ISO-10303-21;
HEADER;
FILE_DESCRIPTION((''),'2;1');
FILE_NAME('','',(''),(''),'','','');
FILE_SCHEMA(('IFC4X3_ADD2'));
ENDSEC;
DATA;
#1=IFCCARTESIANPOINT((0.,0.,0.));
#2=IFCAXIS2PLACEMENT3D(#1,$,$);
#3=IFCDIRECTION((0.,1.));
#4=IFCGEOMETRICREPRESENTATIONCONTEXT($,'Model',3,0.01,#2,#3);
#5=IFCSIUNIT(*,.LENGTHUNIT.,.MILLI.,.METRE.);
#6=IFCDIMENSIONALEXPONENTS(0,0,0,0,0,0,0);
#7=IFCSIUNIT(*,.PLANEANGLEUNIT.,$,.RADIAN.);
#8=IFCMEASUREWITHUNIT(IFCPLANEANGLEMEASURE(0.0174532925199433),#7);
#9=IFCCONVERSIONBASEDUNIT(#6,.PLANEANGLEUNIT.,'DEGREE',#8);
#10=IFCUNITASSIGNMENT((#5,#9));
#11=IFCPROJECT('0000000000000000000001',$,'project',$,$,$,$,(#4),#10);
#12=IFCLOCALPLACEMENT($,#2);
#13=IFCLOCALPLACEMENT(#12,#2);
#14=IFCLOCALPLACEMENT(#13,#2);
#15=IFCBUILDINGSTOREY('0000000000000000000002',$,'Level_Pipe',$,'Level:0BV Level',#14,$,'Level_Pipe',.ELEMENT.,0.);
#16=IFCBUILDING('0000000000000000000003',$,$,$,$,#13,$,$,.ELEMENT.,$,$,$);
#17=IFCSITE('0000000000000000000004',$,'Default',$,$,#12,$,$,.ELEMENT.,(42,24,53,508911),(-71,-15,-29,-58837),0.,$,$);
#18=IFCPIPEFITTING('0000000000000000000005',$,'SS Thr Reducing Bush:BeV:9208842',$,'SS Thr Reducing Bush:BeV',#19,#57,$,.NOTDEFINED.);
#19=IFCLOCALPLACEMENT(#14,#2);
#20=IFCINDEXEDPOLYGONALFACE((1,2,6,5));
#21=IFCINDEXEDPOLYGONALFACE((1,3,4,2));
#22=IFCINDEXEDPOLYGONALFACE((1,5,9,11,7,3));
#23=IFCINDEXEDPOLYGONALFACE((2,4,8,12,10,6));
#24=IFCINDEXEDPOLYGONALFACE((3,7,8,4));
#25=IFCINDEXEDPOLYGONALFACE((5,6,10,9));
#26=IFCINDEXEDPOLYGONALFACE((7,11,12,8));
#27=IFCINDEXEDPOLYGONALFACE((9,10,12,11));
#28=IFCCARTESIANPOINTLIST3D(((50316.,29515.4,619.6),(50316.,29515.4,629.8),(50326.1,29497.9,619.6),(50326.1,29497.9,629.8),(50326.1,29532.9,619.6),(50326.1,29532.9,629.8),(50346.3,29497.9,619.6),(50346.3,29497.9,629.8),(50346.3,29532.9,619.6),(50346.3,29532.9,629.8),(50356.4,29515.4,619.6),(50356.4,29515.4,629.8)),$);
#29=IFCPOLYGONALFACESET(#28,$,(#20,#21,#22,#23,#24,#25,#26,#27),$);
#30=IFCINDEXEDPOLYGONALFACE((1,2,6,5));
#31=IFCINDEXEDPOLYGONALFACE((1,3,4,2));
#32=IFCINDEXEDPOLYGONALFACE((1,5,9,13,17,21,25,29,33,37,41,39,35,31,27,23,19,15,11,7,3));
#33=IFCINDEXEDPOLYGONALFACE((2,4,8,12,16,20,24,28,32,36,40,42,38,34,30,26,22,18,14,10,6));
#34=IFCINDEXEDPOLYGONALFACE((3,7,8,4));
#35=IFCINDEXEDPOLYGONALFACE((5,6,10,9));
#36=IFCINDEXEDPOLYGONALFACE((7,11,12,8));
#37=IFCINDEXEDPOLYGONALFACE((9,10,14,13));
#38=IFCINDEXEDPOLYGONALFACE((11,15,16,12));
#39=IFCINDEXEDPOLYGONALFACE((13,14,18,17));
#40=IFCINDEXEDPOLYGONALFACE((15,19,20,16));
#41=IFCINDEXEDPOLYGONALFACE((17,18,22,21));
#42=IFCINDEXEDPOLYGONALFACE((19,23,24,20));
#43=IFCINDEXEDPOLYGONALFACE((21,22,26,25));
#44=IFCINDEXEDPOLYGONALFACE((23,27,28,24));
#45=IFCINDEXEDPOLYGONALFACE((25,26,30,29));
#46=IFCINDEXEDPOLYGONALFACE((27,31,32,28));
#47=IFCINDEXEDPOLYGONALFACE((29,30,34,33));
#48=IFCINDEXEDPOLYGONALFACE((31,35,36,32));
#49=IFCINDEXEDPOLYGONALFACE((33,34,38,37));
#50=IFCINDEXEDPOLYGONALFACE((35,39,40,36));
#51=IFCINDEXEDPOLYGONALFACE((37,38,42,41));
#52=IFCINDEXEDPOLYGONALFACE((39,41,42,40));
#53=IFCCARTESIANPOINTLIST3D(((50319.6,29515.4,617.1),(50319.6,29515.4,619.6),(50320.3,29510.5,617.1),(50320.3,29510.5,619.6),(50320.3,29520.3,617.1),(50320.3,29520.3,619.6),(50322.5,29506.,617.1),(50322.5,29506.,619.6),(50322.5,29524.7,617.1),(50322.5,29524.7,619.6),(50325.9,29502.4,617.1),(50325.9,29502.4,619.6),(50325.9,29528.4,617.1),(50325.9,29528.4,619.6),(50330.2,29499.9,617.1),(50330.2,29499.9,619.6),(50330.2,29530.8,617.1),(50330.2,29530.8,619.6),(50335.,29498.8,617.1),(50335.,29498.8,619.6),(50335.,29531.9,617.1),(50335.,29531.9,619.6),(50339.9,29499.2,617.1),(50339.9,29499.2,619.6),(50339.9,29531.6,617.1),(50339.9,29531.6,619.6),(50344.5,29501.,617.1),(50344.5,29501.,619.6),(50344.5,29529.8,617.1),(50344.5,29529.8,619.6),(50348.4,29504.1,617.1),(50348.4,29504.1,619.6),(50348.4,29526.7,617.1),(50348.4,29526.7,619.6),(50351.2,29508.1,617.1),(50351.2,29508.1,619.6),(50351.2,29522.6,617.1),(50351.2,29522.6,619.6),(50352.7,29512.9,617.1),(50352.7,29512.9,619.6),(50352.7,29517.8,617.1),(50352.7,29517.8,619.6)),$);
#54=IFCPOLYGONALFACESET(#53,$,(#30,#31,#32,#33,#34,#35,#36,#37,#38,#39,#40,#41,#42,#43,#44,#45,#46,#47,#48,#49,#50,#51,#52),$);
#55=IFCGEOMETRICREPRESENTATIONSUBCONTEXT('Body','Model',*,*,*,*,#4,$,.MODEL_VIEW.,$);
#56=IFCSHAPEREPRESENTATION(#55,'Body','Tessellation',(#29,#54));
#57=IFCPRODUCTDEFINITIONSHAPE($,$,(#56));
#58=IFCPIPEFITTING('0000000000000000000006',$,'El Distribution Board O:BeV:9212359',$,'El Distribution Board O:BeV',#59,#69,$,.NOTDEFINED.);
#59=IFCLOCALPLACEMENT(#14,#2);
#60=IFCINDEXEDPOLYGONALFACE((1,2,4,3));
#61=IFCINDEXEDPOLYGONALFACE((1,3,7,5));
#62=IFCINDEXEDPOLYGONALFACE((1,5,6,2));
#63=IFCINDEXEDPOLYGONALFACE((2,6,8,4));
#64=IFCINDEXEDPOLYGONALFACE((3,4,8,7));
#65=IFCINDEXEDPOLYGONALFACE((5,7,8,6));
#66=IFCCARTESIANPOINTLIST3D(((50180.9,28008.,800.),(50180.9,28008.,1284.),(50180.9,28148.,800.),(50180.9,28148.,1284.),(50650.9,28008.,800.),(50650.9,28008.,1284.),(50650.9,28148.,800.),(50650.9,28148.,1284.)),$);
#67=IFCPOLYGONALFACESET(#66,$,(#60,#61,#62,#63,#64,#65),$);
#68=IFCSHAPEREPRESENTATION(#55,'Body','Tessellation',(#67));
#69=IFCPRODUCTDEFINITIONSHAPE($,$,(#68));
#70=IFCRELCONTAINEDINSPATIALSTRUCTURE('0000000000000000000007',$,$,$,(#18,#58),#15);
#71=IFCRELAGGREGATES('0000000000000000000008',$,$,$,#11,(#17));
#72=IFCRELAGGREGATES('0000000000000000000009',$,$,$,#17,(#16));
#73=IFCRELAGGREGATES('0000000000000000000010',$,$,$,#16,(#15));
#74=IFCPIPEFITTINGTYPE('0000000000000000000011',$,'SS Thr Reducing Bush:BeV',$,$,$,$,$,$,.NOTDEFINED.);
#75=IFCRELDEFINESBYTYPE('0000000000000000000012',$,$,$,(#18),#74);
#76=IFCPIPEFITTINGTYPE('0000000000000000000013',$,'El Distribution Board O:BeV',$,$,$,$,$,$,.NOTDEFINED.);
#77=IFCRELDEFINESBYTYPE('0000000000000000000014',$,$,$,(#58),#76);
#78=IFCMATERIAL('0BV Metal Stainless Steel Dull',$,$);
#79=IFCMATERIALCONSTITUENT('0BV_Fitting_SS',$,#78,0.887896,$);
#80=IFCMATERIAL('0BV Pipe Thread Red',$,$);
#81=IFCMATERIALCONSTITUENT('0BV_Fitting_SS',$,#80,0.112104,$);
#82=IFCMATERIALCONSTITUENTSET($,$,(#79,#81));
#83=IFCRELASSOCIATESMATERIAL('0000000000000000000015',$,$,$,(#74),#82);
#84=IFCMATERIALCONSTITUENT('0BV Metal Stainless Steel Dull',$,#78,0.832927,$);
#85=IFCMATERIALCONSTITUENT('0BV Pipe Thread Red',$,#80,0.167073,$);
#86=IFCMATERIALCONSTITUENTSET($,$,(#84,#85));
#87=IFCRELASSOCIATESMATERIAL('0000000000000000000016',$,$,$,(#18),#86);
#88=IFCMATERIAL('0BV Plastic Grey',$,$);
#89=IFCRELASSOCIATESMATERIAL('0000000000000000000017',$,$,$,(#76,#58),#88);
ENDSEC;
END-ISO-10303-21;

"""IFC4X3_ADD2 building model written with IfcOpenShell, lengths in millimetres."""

from ifc_helpers import new_model, entity, si_unit, converted_unit, direction, frame, frame_2d, origin, origin_2d_with_axis, place, context, subcontext, project, spatial, polyline, rectangle, circle, outline, extrude, source, transform, mapped, material, constituent, constituent_set, type_object, type_shapes, element, save


model = new_model("IFC4X3_ADD2")

# Units and contexts
model_context = context("Model", 3, precision=0.01, world=origin(), true_north=direction((0.0, 1.0)))
body_context = subcontext(model_context, "Body", "Model", "MODEL_VIEW")
ifc_project = project(units=[si_unit("LENGTHUNIT", "METRE", prefix="MILLI"), converted_unit("PLANEANGLEUNIT", "DEGREE", entity("IfcPlaneAngleMeasure", 0.0174532925199433), si_unit("PLANEANGLEUNIT", "RADIAN"), dimensions=[0, 0, 0, 0, 0, 0, 0])], contexts=[model_context])

# Site, building, storey
site_placement = place(None, origin())
site = spatial("IfcSite", under=ifc_project, at=site_placement, Name="Default", CompositionType="ELEMENT", RefLatitude=(42, 24, 53, 508911), RefLongitude=(-71, -15, -29, -58837), RefElevation=0.0)
building_placement = place(site_placement, origin())
building = spatial("IfcBuilding", under=site, at=building_placement, CompositionType="ELEMENT")
storey_placement = place(building_placement, origin())
storey = spatial("IfcBuildingStorey", under=building, at=storey_placement, Name="Level_Pipe", ObjectType="Level:0BV Level", LongName="Level_Pipe", CompositionType="ELEMENT", Elevation=0.0)

# Pipe fittings
ifc_material_1 = material(Name="0BV Metal Stainless Steel Dull")
ifc_material_2 = material(Name="0BV Pipe Thread Red")
ifc_constituent_1 = constituent(ifc_material_1, Name="0BV Metal Stainless Steel Dull", fraction=0.832927)
ifc_constituent_2 = constituent(ifc_material_2, Name="0BV Pipe Thread Red", fraction=0.167073)
ifc_constituent_set_1 = constituent_set(constituents=[ifc_constituent_1, ifc_constituent_2])
ifc_constituent_3 = constituent(ifc_material_1, Name="0BV_Fitting_SS", fraction=0.887896)
ifc_constituent_4 = constituent(ifc_material_2, Name="0BV_Fitting_SS", fraction=0.112104)
ifc_constituent_set_2 = constituent_set(constituents=[ifc_constituent_3, ifc_constituent_4])
pipe_fitting_type_1 = type_object("IfcPipeFittingType", Name="SS Thr Reducing Bush:BeV", PredefinedType="NOTDEFINED", material=ifc_constituent_set_2)
shared_shape_1 = source(origin(), body_context, "Body", "SweptSolid", [
    extrude(outline(polyline([(-10.1, -17.5), (10.1, -17.5), (20.2, 0.0), (10.1, 17.5), (-10.1, 17.5), (-20.2, 0.0), (-10.1, -17.5)])), frame((2.5, 20.2, 18.2), z_axis=(1.0, 0.0, 0.0), x_axis=(0.0, -0.5, -0.866025)), (0.0, 0.0, 1.0), 10.2),
    extrude(circle(Radius=16.6, at=frame_2d((0.0, 0.0), x_axis=(1.0, 0.0))), frame((0.0, 20.2, 18.2), z_axis=(1.0, 0.0, 0.0), x_axis=(0.0, 1.0, 0.0)), (0.0, 0.0, 1.0), 2.5),
])
type_shapes(pipe_fitting_type_1, [shared_shape_1])
pipe_fitting_1_placement = place(storey_placement, frame((50356.4, 29533.6, 617.1), z_axis=(0.0, -1.0, 0.0), x_axis=(0.0, 0.0, 1.0)))
element("IfcPipeFitting", 1, at=pipe_fitting_1_placement, inside=storey, type_object=pipe_fitting_type_1, material=ifc_constituent_set_1, Name="SS Thr Reducing Bush:BeV:9208842", ObjectType="SS Thr Reducing Bush:BeV", PredefinedType="NOTDEFINED", context=body_context, shape_type="MappedRepresentation", body=[
    mapped(shared_shape_1, transform((0.0, 0.0, 0.0), scale=1.0)),
])
ifc_material_3 = material(Name="0BV Plastic Grey")
pipe_fitting_type_2 = type_object("IfcPipeFittingType", Name="El Distribution Board O:BeV", PredefinedType="NOTDEFINED", material=ifc_material_3)
shared_shape_2 = source(origin(), body_context, "Body", "SweptSolid", [
    extrude(rectangle(XDim=140.0, YDim=470.0, at=origin_2d_with_axis()), frame((0.0, 70.0, 0.0), z_axis=(0.0, 0.0, 1.0), x_axis=(0.0, 1.0, 0.0)), (0.0, 0.0, 1.0), 484.0),
])
type_shapes(pipe_fitting_type_2, [shared_shape_2])
pipe_fitting_2_placement = place(storey_placement, frame((50415.9, 28148.0, 800.0), z_axis=(0.0, 0.0, 1.0), x_axis=(-1.0, 0.0, 0.0)))
element("IfcPipeFitting", 2, at=pipe_fitting_2_placement, inside=storey, type_object=pipe_fitting_type_2, material=ifc_material_3, Name="El Distribution Board O:BeV:9212359", ObjectType="El Distribution Board O:BeV", PredefinedType="NOTDEFINED", context=body_context, shape_type="MappedRepresentation", body=[
    mapped(shared_shape_2, transform((0.0, 0.0, 0.0), scale=1.0)),
])

save(model, "model.ifc")
